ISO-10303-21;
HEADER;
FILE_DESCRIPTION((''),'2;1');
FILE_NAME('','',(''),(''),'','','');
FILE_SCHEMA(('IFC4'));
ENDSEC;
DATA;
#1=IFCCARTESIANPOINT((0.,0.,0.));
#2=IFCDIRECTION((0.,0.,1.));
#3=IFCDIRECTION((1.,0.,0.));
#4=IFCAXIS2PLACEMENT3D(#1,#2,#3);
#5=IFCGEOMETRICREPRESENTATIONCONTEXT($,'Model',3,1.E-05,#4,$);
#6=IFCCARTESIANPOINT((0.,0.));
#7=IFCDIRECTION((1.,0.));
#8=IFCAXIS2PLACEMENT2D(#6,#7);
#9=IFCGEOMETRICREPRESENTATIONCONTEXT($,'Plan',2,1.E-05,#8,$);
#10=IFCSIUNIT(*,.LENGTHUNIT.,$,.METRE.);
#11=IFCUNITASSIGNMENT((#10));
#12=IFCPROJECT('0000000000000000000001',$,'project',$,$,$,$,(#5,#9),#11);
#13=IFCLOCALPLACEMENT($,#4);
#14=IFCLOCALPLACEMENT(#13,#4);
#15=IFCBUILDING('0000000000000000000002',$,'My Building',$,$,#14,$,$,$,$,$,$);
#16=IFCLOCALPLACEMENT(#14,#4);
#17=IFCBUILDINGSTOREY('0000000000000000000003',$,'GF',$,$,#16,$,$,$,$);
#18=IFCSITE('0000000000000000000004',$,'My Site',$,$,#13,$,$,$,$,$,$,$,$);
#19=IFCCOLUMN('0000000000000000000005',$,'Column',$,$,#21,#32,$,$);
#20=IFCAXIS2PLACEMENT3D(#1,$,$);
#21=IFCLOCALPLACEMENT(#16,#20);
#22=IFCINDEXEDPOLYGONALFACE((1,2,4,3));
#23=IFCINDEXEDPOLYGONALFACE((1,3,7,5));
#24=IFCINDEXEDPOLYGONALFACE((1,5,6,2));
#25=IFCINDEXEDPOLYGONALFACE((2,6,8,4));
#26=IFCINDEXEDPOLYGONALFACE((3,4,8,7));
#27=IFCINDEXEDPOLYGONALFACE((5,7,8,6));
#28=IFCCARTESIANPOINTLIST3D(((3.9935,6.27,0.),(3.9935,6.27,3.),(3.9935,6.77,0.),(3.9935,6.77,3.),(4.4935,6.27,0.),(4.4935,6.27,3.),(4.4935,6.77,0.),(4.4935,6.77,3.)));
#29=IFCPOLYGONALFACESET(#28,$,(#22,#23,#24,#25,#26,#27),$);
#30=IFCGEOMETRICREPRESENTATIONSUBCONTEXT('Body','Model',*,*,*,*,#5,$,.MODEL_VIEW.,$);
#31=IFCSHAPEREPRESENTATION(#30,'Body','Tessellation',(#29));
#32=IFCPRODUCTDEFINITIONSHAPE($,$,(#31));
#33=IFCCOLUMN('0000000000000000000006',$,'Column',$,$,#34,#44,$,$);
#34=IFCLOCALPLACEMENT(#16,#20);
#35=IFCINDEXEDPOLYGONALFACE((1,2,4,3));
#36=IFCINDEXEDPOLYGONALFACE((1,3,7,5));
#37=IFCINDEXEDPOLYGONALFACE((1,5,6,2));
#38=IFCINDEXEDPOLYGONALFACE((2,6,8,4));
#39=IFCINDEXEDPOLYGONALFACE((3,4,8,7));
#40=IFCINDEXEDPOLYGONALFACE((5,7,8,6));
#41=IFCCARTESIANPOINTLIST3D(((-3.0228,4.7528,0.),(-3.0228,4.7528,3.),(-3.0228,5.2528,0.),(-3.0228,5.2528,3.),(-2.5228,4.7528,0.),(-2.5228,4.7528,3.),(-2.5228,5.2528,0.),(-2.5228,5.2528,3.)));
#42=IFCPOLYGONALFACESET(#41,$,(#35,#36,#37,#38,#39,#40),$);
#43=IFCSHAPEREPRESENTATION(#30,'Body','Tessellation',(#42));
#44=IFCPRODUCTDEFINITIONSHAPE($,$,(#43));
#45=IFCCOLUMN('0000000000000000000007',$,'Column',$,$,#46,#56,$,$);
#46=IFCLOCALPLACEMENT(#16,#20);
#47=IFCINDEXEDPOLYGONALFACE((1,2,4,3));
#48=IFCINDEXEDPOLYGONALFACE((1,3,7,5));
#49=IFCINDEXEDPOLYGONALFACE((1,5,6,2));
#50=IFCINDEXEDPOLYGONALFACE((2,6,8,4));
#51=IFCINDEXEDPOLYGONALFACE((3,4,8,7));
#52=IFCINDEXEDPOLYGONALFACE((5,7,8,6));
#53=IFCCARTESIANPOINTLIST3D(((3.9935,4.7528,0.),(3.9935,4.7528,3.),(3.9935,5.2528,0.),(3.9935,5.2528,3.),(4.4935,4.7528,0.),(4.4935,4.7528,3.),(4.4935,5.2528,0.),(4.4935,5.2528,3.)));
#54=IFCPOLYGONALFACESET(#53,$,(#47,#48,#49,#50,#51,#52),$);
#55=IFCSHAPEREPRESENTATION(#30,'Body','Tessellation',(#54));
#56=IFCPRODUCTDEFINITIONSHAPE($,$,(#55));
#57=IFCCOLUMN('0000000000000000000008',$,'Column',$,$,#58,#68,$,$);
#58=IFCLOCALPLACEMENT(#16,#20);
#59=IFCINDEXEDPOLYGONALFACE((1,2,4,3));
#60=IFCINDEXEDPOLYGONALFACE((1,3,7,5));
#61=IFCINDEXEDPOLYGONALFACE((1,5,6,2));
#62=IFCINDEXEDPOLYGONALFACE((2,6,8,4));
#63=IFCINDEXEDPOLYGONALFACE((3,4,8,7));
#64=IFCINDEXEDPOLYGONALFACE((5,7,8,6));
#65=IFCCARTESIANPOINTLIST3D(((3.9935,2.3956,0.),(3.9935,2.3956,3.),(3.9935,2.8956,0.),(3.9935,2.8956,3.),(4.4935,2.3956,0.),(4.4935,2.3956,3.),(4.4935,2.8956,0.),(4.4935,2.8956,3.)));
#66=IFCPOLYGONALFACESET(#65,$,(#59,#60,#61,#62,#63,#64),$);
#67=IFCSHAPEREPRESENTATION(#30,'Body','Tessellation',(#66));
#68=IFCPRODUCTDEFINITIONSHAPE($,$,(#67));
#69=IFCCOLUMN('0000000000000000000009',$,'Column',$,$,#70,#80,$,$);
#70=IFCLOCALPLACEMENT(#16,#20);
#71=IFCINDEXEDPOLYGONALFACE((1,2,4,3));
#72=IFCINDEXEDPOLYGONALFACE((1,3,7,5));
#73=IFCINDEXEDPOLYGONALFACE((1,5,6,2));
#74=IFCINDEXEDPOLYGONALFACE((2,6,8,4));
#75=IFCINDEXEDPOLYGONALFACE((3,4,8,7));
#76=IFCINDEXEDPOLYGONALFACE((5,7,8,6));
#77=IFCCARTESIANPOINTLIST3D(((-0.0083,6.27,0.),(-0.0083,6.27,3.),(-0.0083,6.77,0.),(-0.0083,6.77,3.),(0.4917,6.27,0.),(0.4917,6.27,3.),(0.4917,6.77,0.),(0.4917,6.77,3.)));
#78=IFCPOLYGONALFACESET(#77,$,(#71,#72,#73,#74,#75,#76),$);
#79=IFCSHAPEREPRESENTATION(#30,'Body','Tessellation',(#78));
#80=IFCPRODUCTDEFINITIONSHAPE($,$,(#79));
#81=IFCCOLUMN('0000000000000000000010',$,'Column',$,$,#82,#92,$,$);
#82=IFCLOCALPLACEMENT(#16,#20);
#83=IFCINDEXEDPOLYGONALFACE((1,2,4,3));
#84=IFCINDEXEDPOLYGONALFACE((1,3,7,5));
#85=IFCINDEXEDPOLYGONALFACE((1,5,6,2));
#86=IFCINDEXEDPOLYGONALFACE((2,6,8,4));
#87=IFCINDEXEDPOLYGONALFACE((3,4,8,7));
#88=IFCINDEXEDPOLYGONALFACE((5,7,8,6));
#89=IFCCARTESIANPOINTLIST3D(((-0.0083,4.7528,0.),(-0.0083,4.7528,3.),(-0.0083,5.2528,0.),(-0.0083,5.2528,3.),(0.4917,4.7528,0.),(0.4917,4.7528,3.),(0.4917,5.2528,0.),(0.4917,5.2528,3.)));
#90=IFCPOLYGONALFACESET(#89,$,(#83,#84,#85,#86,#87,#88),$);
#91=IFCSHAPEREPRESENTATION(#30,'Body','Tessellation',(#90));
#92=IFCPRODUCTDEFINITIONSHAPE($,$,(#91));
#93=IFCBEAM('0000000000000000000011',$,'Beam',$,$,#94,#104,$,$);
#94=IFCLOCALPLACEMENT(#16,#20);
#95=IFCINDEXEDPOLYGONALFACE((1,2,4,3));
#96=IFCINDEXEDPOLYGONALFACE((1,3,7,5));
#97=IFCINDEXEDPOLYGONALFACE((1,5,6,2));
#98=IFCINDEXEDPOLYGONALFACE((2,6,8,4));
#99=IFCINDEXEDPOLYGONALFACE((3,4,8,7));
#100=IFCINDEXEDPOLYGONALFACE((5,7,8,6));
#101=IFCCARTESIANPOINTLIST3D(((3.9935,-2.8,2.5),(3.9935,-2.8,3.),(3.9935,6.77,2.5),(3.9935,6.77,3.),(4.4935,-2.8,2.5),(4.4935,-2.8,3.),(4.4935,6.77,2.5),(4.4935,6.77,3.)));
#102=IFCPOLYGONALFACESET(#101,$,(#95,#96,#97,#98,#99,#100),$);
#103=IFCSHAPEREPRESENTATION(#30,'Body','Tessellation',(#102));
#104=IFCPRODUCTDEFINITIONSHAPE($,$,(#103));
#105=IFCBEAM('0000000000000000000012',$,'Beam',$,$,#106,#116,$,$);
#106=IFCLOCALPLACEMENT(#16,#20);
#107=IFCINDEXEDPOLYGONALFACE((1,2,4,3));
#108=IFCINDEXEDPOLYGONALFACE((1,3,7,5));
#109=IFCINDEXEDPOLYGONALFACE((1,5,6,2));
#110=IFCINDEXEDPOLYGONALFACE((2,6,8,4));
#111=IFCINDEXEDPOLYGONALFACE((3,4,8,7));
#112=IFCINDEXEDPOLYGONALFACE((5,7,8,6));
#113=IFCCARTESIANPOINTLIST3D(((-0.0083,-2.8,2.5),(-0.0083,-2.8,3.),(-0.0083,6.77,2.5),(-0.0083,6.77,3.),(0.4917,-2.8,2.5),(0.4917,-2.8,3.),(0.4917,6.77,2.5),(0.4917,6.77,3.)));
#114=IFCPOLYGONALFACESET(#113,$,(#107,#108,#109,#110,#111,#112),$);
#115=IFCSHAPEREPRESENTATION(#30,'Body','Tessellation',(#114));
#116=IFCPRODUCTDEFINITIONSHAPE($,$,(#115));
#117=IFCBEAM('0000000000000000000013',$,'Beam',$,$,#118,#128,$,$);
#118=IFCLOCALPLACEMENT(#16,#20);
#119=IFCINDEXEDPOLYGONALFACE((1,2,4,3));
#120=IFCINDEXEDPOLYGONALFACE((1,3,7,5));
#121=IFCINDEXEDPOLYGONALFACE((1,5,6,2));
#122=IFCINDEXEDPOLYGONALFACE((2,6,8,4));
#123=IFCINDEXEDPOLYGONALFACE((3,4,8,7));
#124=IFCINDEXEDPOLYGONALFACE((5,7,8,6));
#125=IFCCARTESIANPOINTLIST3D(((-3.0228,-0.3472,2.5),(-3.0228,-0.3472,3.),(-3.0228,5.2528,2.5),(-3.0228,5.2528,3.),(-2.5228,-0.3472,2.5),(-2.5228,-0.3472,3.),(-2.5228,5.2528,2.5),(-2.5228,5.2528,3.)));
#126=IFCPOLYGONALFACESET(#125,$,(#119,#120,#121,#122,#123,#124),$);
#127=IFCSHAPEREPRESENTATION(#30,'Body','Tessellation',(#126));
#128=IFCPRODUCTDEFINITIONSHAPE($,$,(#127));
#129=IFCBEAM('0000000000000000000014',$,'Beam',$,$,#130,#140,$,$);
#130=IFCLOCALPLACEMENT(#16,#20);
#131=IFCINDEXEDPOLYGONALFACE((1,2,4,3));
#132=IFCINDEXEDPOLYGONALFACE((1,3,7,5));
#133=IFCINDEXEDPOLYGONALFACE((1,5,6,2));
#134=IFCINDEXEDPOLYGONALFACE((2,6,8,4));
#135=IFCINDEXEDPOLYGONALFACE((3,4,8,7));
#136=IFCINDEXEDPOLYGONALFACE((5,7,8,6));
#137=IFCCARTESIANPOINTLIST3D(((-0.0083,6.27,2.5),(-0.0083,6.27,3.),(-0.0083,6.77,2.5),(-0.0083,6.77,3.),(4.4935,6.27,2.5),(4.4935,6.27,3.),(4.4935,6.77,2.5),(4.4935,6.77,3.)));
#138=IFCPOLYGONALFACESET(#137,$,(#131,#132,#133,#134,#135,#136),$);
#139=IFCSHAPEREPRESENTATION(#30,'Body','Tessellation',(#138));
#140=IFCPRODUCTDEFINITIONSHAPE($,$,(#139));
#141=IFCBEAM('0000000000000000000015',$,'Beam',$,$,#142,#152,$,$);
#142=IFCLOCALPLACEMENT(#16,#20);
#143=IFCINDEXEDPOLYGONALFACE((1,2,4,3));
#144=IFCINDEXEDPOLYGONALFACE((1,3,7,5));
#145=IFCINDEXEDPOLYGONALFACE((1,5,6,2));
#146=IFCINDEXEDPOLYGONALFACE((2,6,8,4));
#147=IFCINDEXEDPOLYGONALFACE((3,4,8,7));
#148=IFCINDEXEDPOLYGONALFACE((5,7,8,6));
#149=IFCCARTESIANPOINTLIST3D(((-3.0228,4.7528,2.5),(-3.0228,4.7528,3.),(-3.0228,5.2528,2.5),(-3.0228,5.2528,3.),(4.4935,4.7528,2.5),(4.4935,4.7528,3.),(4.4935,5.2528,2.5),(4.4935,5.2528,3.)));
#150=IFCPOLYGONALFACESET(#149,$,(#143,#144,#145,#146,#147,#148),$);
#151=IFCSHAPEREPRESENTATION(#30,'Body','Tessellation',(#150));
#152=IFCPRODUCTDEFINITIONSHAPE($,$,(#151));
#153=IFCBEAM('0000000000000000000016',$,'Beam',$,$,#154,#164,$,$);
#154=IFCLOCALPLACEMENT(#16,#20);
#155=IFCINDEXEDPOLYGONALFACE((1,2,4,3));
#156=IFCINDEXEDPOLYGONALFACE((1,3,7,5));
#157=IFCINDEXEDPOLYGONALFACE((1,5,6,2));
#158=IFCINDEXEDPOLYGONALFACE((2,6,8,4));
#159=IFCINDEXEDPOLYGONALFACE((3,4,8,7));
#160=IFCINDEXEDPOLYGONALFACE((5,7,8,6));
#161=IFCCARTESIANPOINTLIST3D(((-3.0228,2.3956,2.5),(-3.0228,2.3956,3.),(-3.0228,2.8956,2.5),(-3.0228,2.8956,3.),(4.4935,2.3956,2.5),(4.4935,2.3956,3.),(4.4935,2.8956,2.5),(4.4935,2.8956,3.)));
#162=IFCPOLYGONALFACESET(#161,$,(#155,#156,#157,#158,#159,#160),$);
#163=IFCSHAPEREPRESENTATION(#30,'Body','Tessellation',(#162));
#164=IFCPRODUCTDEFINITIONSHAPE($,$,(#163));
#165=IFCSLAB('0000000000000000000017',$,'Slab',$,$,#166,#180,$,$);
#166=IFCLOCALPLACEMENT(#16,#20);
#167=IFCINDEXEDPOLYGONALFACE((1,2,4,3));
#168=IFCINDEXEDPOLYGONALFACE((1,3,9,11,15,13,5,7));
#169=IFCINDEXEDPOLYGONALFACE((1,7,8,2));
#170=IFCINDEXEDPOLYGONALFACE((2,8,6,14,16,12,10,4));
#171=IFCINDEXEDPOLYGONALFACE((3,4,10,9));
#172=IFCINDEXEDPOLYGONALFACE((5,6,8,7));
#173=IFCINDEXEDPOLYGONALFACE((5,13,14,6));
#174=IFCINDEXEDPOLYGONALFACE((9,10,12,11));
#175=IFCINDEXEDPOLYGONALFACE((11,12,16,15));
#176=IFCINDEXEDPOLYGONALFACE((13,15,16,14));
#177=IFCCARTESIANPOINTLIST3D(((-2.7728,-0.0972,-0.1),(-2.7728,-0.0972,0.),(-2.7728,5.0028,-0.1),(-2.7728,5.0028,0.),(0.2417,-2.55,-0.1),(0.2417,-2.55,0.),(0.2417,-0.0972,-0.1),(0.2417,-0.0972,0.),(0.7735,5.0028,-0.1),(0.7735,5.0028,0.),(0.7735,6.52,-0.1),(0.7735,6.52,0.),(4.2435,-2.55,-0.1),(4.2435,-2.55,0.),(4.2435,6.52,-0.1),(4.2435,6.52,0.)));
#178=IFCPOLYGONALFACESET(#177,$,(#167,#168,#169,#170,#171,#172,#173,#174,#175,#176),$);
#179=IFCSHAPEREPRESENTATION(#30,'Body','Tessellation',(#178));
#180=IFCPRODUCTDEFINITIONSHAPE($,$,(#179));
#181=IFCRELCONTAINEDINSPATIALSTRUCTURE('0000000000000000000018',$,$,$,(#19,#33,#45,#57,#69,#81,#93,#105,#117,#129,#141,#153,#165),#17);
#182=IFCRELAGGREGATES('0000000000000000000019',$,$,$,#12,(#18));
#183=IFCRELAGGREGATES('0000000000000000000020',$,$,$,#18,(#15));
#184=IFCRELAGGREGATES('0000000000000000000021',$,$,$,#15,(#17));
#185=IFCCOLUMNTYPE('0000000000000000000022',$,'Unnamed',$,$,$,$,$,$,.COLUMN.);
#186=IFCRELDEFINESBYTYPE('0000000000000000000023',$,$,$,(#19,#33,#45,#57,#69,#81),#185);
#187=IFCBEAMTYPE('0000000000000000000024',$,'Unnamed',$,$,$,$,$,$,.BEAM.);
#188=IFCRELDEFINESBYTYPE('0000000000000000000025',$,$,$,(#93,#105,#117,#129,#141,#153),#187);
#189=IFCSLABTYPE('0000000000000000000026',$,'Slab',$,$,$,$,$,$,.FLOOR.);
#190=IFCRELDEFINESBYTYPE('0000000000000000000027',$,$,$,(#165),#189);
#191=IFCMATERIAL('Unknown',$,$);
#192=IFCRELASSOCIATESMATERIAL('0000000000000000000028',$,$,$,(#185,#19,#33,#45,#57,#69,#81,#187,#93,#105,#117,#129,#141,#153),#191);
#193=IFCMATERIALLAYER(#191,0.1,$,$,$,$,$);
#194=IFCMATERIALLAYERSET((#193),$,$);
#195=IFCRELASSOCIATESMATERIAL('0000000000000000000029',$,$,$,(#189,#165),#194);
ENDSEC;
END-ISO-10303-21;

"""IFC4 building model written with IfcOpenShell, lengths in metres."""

from ifc_helpers import new_model, si_unit, frame, origin_with_axes, origin_2d_with_axis, place, context, subcontext, project, spatial, indexed_curve, rectangle, outline, extrude, material, layer, layer_set, layer_usage, material_profile, profile_set, profile_usage, type_object, element, save


model = new_model("IFC4")

# Units and contexts
model_context = context("Model", 3, precision=1e-05, world=origin_with_axes())
plan_context = context("Plan", 2, precision=1e-05, world=origin_2d_with_axis())
body_context_1 = subcontext(model_context, "Body", "Model", "MODEL_VIEW")
ifc_project = project(units=[si_unit("LENGTHUNIT", "METRE")], contexts=[model_context, plan_context])

# Site, building, storey
site_placement = place(None, origin_with_axes())
site = spatial("IfcSite", under=ifc_project, at=site_placement, Name="My Site")
building_placement = place(site_placement, origin_with_axes())
building = spatial("IfcBuilding", under=site, at=building_placement, Name="My Building")
storey_placement = place(building_placement, origin_with_axes())
storey = spatial("IfcBuildingStorey", under=building, at=storey_placement, Name="GF")

# Columns
ifc_material_1 = material(Name="Unknown")
ifc_material_profile_1 = material_profile(ifc_material_1, rectangle(XDim=0.5, YDim=0.5))
ifc_profile_set_1 = profile_set([ifc_material_profile_1])
ifc_profile_usage_1 = profile_usage(ifc_profile_set_1, cardinal=5)
column_type = type_object("IfcColumnType", Name="Unnamed", PredefinedType="COLUMN", material=ifc_profile_set_1)
column_1_placement = place(storey_placement, frame((4.2435, 6.52, 0.0), z_axis=(0.0, 0.0, 1.0), x_axis=(1.0, 0.0, 0.0)))
element("IfcColumn", 1, at=column_1_placement, inside=storey, type_object=column_type, material=ifc_profile_usage_1, Name="Column", context=body_context_1, shape_type="SweptSolid", body=[
    extrude(rectangle(XDim=0.5, YDim=0.5), origin_with_axes(), (0.0, 0.0, 1.0), 3.0),
])
ifc_profile_usage_2 = profile_usage(ifc_profile_set_1, cardinal=5)
column_2_placement = place(storey_placement, frame((-2.7728, 5.0028, 0.0), z_axis=(0.0, 0.0, 1.0), x_axis=(1.0, 0.0, 0.0)))
element("IfcColumn", 2, at=column_2_placement, inside=storey, type_object=column_type, material=ifc_profile_usage_2, Name="Column", context=body_context_1, shape_type="SweptSolid", body=[
    extrude(rectangle(XDim=0.5, YDim=0.5), origin_with_axes(), (0.0, 0.0, 1.0), 3.0),
])
ifc_profile_usage_3 = profile_usage(ifc_profile_set_1, cardinal=5)
column_3_placement = place(storey_placement, frame((4.2435, 5.0028, 0.0), z_axis=(0.0, 0.0, 1.0), x_axis=(1.0, 0.0, 0.0)))
element("IfcColumn", 3, at=column_3_placement, inside=storey, type_object=column_type, material=ifc_profile_usage_3, Name="Column", context=body_context_1, shape_type="SweptSolid", body=[
    extrude(rectangle(XDim=0.5, YDim=0.5), origin_with_axes(), (0.0, 0.0, 1.0), 3.0),
])
ifc_profile_usage_4 = profile_usage(ifc_profile_set_1, cardinal=5)
column_4_placement = place(storey_placement, frame((4.2435, 2.6456, 0.0), z_axis=(0.0, 0.0, 1.0), x_axis=(1.0, 0.0, 0.0)))
element("IfcColumn", 4, at=column_4_placement, inside=storey, type_object=column_type, material=ifc_profile_usage_4, Name="Column", context=body_context_1, shape_type="SweptSolid", body=[
    extrude(rectangle(XDim=0.5, YDim=0.5), origin_with_axes(), (0.0, 0.0, 1.0), 3.0),
])
ifc_profile_usage_5 = profile_usage(ifc_profile_set_1, cardinal=5)
column_5_placement = place(storey_placement, frame((0.2417, 6.52, 0.0), z_axis=(0.0, 0.0, 1.0), x_axis=(1.0, 0.0, 0.0)))
element("IfcColumn", 5, at=column_5_placement, inside=storey, type_object=column_type, material=ifc_profile_usage_5, Name="Column", context=body_context_1, shape_type="SweptSolid", body=[
    extrude(rectangle(XDim=0.5, YDim=0.5), origin_with_axes(), (0.0, 0.0, 1.0), 3.0),
])
ifc_profile_usage_6 = profile_usage(ifc_profile_set_1, cardinal=5)
column_6_placement = place(storey_placement, frame((0.2417, 5.0028, 0.0), z_axis=(0.0, 0.0, 1.0), x_axis=(1.0, 0.0, 0.0)))
element("IfcColumn", 6, at=column_6_placement, inside=storey, type_object=column_type, material=ifc_profile_usage_6, Name="Column", context=body_context_1, shape_type="SweptSolid", body=[
    extrude(rectangle(XDim=0.5, YDim=0.5), origin_with_axes(), (0.0, 0.0, 1.0), 3.0),
])

# Beams
ifc_material_profile_2 = material_profile(ifc_material_1, rectangle(XDim=0.5, YDim=0.5))
ifc_profile_set_2 = profile_set([ifc_material_profile_2])
ifc_profile_usage_7 = profile_usage(ifc_profile_set_2, cardinal=7)
beam_type = type_object("IfcBeamType", Name="Unnamed", PredefinedType="BEAM", material=ifc_profile_set_2)
beam_1_placement = place(storey_placement, frame((4.4935, 6.77, 3.0), z_axis=(0.0, -1.0, 0.0), x_axis=(1.0, 0.0, 0.0)))
element("IfcBeam", 7, at=beam_1_placement, inside=storey, type_object=beam_type, material=ifc_profile_usage_7, Name="Beam", context=body_context_1, shape_type="SweptSolid", body=[
    extrude(rectangle(XDim=0.5, YDim=0.5), frame((-0.25, -0.25, 0.0), z_axis=(0.0, 0.0, 1.0), x_axis=(1.0, 0.0, 0.0)), (0.0, 0.0, 1.0), 9.57),
])
ifc_profile_usage_8 = profile_usage(ifc_profile_set_2, cardinal=7)
beam_2_placement = place(storey_placement, frame((0.4917, 6.77, 3.0), z_axis=(0.0, -1.0, 0.0), x_axis=(1.0, 0.0, 0.0)))
element("IfcBeam", 8, at=beam_2_placement, inside=storey, type_object=beam_type, material=ifc_profile_usage_8, Name="Beam", context=body_context_1, shape_type="SweptSolid", body=[
    extrude(rectangle(XDim=0.5, YDim=0.5), frame((-0.25, -0.25, 0.0), z_axis=(0.0, 0.0, 1.0), x_axis=(1.0, 0.0, 0.0)), (0.0, 0.0, 1.0), 9.57),
])
ifc_profile_usage_9 = profile_usage(ifc_profile_set_2, cardinal=7)
beam_3_placement = place(storey_placement, frame((-2.5228, 5.2528, 3.0), z_axis=(0.0, -1.0, 0.0), x_axis=(1.0, 0.0, 0.0)))
element("IfcBeam", 9, at=beam_3_placement, inside=storey, type_object=beam_type, material=ifc_profile_usage_9, Name="Beam", context=body_context_1, shape_type="SweptSolid", body=[
    extrude(rectangle(XDim=0.5, YDim=0.5), frame((-0.25, -0.25, 0.0), z_axis=(0.0, 0.0, 1.0), x_axis=(1.0, 0.0, 0.0)), (0.0, 0.0, 1.0), 5.6),
])
ifc_profile_usage_10 = profile_usage(ifc_profile_set_2, cardinal=7)
beam_4_placement = place(storey_placement, frame((-0.0083, 6.77, 3.0), z_axis=(1.0, 0.0, 0.0), x_axis=(0.0, 1.0, 0.0)))
element("IfcBeam", 10, at=beam_4_placement, inside=storey, type_object=beam_type, material=ifc_profile_usage_10, Name="Beam", context=body_context_1, shape_type="SweptSolid", body=[
    extrude(rectangle(XDim=0.5, YDim=0.5), frame((-0.25, -0.25, 0.0), z_axis=(0.0, 0.0, 1.0), x_axis=(1.0, 0.0, 0.0)), (0.0, 0.0, 1.0), 4.5018),
])
ifc_profile_usage_11 = profile_usage(ifc_profile_set_2, cardinal=7)
beam_5_placement = place(storey_placement, frame((-3.0228, 5.2528, 3.0), z_axis=(1.0, 0.0, 0.0), x_axis=(0.0, 1.0, 0.0)))
element("IfcBeam", 11, at=beam_5_placement, inside=storey, type_object=beam_type, material=ifc_profile_usage_11, Name="Beam", context=body_context_1, shape_type="SweptSolid", body=[
    extrude(rectangle(XDim=0.5, YDim=0.5), frame((-0.25, -0.25, 0.0), z_axis=(0.0, 0.0, 1.0), x_axis=(1.0, 0.0, 0.0)), (0.0, 0.0, 1.0), 7.5163),
])
ifc_profile_usage_12 = profile_usage(ifc_profile_set_2, cardinal=7)
beam_6_placement = place(storey_placement, frame((-3.0228, 2.8956, 3.0), z_axis=(1.0, 0.0, 0.0), x_axis=(0.0, 1.0, 0.0)))
element("IfcBeam", 12, at=beam_6_placement, inside=storey, type_object=beam_type, material=ifc_profile_usage_12, Name="Beam", context=body_context_1, shape_type="SweptSolid", body=[
    extrude(rectangle(XDim=0.5, YDim=0.5), frame((-0.25, -0.25, 0.0), z_axis=(0.0, 0.0, 1.0), x_axis=(1.0, 0.0, 0.0)), (0.0, 0.0, 1.0), 7.5163),
])

# Slab
ifc_layer_1 = layer(ifc_material_1, 0.1)
ifc_layer_set_1 = layer_set([ifc_layer_1])
ifc_layer_usage_1 = layer_usage(ifc_layer_set_1, "AXIS3", "POSITIVE", -0.1)
slab_type = type_object("IfcSlabType", Name="Slab", PredefinedType="FLOOR", material=ifc_layer_set_1)
slab_placement = place(storey_placement, frame((4.2435, 6.52, 0.0), z_axis=(0.0, 0.0, 1.0), x_axis=(1.0, 0.0, 0.0)))
element("IfcSlab", 13, at=slab_placement, inside=storey, type_object=slab_type, material=ifc_layer_usage_1, Name="Slab", context=body_context_1, shape_type="SweptSolid", body=[
    extrude(outline(indexed_curve([(0.0, 0.0), (-3.47, 0.0), (-3.47, -1.5172), (-7.0163, -1.5172), (-7.0163, -6.6172), (-4.0018, -6.6172), (-4.0018, -9.07), (0.0, -9.07), (0.0, 0.0)])), frame((0.0, 0.0, -0.1), z_axis=(0.0, 0.0, 1.0), x_axis=(1.0, 0.0, 0.0)), (0.0, 0.0, 1.0), 0.1),
])

save(model, "model.ifc")
